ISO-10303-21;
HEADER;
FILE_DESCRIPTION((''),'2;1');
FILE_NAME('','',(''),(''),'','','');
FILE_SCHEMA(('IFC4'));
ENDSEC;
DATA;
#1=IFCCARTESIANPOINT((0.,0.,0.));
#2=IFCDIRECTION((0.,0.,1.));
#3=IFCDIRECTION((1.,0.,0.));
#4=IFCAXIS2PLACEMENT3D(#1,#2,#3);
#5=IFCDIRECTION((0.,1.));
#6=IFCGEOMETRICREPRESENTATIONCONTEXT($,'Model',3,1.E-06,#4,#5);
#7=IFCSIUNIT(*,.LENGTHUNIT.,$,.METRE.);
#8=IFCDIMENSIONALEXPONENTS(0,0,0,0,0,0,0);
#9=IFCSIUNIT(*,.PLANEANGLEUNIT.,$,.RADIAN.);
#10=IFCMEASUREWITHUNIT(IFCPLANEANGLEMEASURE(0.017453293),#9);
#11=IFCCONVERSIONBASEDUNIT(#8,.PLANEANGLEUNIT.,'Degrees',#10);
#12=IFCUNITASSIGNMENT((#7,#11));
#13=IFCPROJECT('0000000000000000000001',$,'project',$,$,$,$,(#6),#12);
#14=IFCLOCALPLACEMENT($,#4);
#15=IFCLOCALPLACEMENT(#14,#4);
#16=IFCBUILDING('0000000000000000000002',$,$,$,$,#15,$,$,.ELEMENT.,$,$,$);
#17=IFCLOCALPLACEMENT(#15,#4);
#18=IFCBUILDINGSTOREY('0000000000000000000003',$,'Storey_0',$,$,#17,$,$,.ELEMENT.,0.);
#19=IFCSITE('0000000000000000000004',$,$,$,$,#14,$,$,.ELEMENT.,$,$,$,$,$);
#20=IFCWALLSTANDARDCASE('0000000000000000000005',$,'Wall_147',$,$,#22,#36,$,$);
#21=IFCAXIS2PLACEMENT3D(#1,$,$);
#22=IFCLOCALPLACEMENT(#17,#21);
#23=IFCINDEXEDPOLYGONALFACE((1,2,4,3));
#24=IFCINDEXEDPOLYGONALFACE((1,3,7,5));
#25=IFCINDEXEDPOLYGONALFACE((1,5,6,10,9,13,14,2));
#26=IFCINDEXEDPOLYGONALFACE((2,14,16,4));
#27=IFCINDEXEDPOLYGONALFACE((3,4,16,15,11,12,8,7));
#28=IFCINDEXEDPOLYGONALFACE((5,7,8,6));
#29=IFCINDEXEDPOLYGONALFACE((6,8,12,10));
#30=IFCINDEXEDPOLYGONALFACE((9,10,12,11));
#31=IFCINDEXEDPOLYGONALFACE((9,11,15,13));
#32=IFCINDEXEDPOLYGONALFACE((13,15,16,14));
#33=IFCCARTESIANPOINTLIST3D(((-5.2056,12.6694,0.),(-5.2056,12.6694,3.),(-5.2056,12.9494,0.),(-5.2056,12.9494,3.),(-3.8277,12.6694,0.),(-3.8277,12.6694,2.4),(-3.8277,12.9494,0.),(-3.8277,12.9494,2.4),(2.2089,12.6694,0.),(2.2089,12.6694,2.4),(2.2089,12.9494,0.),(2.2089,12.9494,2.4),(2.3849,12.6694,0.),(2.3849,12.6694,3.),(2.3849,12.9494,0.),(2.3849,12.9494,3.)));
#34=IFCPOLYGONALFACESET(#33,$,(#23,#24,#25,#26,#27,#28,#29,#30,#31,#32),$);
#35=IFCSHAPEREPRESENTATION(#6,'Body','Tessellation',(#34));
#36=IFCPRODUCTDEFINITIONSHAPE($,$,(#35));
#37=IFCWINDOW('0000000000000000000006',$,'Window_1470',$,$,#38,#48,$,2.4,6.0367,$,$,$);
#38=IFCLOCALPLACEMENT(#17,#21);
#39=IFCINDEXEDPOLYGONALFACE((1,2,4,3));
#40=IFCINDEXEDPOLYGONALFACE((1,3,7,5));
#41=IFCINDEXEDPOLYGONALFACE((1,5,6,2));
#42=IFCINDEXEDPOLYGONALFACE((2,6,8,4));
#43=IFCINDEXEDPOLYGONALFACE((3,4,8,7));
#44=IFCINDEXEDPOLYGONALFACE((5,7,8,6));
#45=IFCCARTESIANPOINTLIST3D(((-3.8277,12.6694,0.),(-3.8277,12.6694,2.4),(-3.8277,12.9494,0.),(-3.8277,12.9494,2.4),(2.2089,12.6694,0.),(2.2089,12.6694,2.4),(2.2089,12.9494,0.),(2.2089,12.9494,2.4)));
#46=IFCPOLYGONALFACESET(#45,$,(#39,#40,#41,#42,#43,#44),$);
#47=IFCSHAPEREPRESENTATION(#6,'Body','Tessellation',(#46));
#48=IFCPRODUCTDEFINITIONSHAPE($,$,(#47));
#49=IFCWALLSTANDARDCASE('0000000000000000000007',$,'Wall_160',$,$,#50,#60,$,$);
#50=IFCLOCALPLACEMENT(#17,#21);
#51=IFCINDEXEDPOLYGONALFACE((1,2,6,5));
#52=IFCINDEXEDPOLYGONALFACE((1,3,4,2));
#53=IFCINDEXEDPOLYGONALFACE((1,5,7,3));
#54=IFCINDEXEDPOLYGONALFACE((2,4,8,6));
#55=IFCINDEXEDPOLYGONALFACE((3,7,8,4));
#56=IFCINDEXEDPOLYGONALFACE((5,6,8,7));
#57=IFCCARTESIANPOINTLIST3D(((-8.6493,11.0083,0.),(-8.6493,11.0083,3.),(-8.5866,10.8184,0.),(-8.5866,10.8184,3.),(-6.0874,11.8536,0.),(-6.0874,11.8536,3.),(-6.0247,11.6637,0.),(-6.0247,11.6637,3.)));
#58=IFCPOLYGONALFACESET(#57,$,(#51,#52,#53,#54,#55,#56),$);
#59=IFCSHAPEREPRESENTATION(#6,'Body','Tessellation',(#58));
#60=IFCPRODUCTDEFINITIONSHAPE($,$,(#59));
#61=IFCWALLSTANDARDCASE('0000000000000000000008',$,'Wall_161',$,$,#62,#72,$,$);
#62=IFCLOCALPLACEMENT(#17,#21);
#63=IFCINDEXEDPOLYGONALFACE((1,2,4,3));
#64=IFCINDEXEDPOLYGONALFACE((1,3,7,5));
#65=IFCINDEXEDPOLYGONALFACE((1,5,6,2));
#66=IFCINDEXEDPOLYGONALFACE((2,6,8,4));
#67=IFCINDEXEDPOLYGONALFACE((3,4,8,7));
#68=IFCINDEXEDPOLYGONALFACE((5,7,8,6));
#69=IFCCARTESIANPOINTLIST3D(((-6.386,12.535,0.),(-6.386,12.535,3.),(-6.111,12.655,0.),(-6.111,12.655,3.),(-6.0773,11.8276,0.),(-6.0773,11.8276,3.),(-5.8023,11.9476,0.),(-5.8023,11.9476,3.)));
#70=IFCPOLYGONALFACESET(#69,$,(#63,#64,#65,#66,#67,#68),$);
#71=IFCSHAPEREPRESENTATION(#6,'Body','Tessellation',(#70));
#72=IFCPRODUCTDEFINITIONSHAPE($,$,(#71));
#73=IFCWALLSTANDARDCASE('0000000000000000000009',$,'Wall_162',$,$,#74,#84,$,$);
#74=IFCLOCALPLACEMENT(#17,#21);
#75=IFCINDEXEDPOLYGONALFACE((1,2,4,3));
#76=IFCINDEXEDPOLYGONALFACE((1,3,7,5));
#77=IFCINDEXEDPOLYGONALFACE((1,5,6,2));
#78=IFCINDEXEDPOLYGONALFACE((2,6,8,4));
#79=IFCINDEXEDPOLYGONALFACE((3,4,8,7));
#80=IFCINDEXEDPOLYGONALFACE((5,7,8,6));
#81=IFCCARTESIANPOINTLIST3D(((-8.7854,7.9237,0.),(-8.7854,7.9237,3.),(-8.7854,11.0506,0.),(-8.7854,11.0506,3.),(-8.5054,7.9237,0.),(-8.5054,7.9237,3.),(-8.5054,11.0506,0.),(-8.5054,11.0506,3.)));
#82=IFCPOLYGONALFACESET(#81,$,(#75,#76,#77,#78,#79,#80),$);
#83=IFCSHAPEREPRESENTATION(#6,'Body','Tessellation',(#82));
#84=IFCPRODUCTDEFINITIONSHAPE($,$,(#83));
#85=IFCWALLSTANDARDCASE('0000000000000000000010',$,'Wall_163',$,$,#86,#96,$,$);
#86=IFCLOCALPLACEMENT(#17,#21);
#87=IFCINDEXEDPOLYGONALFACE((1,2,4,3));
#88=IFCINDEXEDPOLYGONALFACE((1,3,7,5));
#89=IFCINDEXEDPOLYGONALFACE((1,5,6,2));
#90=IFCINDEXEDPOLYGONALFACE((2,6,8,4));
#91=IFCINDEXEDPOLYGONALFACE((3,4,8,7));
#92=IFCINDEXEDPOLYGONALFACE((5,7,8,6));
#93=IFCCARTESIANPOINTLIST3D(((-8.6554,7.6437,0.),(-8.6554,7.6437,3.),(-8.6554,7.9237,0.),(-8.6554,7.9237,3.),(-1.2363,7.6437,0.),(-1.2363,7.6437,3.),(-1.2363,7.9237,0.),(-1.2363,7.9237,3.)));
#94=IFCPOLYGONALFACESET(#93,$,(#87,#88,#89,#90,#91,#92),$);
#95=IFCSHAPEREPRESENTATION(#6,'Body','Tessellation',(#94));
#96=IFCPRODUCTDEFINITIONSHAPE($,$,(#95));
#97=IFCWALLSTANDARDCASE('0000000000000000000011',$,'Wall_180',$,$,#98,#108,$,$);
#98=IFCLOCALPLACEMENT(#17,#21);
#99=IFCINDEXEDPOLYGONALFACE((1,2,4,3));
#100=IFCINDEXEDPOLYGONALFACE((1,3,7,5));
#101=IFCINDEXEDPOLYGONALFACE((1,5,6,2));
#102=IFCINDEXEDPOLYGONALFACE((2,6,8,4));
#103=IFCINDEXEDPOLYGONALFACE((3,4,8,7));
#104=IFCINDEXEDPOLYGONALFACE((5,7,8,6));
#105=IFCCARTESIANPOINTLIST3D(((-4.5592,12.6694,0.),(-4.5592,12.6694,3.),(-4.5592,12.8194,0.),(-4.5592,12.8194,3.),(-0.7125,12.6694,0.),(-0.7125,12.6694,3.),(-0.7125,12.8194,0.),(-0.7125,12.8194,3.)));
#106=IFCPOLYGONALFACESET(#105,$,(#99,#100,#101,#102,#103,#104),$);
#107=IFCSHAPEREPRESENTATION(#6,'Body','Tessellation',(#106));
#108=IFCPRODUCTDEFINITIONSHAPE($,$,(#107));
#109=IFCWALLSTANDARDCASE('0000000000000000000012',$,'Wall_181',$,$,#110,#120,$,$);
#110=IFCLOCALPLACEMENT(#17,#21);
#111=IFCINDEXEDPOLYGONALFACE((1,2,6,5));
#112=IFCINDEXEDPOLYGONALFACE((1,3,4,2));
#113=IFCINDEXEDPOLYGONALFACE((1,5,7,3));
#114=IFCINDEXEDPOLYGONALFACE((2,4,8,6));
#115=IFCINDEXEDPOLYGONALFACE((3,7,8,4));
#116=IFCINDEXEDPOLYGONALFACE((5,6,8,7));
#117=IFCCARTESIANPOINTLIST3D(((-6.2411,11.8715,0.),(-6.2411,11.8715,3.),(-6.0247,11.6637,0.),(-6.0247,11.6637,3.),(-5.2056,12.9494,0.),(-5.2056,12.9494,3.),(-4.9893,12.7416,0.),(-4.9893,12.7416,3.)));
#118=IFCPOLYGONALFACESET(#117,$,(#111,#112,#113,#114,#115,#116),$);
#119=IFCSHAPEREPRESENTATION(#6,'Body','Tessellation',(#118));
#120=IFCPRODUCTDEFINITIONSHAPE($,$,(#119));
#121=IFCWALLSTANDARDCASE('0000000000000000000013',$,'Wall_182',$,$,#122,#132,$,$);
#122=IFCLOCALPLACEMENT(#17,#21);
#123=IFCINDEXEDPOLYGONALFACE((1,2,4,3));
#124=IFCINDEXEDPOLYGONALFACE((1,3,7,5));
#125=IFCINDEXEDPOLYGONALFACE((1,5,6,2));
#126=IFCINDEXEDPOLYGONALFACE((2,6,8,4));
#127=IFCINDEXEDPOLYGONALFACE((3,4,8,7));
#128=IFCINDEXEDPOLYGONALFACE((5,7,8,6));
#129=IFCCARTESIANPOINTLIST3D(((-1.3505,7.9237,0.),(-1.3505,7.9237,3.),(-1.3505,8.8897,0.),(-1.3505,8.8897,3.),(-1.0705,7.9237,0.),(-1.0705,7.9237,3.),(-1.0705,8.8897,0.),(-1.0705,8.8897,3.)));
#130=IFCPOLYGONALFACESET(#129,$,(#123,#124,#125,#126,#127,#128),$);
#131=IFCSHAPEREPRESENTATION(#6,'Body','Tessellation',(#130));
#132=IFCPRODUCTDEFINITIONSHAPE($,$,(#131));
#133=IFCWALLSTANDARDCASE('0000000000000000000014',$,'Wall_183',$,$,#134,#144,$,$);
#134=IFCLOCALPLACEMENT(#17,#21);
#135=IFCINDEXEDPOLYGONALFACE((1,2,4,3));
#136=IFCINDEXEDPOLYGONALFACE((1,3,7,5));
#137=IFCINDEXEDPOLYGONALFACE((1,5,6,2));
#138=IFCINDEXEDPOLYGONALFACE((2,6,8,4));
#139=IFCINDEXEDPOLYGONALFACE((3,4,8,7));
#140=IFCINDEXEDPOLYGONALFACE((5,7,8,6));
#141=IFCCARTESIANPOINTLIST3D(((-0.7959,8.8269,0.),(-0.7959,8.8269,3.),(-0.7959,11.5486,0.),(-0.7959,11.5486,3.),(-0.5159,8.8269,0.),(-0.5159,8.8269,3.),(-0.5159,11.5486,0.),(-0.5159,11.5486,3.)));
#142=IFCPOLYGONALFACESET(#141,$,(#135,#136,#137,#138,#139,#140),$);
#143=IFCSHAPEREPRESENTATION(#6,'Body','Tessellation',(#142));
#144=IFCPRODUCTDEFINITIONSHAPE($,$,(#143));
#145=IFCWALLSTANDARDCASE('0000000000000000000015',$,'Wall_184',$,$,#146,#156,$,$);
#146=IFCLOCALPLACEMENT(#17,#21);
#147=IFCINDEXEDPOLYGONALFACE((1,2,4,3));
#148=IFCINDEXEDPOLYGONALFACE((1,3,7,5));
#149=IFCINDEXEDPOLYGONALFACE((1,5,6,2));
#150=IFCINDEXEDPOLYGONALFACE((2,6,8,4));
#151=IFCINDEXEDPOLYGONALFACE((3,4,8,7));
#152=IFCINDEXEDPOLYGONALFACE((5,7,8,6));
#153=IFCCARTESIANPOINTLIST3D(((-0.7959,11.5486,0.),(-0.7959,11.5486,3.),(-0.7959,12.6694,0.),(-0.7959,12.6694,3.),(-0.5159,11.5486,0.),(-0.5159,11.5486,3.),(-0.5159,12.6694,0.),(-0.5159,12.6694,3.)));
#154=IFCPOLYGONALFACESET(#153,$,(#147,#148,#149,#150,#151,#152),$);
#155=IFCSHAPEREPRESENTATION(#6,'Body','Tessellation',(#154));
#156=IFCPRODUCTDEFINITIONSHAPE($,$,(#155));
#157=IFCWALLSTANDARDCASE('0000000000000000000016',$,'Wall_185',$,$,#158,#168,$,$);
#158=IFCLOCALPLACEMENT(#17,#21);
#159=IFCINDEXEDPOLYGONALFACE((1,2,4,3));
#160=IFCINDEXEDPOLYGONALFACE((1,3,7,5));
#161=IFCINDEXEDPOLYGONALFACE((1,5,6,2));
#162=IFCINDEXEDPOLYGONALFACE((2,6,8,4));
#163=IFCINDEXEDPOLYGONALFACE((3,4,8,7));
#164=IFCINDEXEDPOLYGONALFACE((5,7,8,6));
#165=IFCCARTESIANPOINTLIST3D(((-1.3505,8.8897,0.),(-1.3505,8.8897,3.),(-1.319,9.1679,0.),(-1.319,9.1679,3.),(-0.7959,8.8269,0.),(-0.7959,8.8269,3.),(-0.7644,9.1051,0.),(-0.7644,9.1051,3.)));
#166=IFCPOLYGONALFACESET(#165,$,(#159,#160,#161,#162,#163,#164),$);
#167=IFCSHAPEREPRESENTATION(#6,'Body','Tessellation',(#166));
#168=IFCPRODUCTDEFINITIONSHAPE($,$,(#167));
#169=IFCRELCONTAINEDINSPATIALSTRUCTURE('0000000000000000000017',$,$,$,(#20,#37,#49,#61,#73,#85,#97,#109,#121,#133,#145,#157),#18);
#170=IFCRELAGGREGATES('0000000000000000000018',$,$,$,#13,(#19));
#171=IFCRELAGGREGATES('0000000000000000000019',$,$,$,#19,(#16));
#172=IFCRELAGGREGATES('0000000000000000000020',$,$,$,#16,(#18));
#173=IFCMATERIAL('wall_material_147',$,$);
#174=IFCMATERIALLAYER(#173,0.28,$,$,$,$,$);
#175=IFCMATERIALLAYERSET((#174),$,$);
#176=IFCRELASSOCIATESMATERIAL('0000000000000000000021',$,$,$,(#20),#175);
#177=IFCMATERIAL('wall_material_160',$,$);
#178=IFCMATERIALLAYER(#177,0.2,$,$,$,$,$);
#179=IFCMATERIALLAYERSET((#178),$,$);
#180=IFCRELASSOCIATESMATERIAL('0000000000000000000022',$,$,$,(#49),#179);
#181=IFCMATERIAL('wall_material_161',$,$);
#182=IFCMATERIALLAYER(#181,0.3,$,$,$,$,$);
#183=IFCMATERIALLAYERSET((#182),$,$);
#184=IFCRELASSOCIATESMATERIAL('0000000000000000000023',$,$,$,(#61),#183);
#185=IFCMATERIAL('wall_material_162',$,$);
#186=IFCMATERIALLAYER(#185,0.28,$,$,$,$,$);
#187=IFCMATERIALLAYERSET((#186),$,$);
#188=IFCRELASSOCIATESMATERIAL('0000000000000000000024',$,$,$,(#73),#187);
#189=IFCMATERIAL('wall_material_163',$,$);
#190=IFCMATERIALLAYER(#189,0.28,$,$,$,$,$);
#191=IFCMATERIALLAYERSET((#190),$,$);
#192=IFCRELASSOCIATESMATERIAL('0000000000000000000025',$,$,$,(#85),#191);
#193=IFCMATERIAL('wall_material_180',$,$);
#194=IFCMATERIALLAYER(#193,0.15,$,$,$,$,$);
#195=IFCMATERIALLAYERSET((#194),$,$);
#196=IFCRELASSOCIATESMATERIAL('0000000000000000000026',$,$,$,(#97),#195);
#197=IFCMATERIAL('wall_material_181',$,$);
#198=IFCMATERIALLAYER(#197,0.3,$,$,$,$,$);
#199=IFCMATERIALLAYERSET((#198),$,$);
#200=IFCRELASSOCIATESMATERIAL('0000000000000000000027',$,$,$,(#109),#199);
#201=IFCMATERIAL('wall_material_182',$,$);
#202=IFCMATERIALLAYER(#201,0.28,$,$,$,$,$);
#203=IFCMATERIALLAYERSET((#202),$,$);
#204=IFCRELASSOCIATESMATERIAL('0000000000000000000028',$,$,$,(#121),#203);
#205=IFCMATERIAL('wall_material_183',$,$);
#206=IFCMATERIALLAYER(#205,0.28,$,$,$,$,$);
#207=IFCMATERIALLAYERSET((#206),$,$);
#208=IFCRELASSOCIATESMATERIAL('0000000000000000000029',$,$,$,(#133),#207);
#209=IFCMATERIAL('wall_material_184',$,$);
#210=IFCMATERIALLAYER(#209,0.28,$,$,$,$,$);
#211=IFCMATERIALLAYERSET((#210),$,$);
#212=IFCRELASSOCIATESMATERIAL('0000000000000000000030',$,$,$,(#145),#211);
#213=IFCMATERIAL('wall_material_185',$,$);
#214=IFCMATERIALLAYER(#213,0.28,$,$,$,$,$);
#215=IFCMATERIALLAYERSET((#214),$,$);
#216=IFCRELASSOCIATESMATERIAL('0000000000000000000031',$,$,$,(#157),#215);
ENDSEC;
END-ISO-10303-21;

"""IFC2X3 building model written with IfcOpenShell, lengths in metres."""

from ifc_helpers import new_model, entity, si_unit, converted_unit, direction, frame, frame_2d, origin_with_axes, place, context, project, spatial, polyline, rectangle, outline, extrude, material, layer, layer_set, layer_usage, element, fill, save


model = new_model("IFC2X3")

# Units and contexts
model_context = context("Model", 3, precision=1e-06, world=origin_with_axes(), true_north=direction((0.0, 1.0)))
ifc_project = project(units=[si_unit("LENGTHUNIT", "METRE"), converted_unit("PLANEANGLEUNIT", "Degrees", entity("IfcPlaneAngleMeasure", 0.017453293), si_unit("PLANEANGLEUNIT", "RADIAN"), dimensions=[0, 0, 0, 0, 0, 0, 0])], contexts=[model_context])

# Site, building, storey
site_placement = place(None, origin_with_axes())
site = spatial("IfcSite", under=ifc_project, at=site_placement, CompositionType="ELEMENT")
building_placement = place(site_placement, origin_with_axes())
building = spatial("IfcBuilding", under=site, at=building_placement, CompositionType="ELEMENT")
storey_placement = place(building_placement, origin_with_axes())
storey = spatial("IfcBuildingStorey", under=building, at=storey_placement, Name="Storey_0", CompositionType="ELEMENT", Elevation=0.0)

# Wall, opening, window
ifc_material_1 = material(Name="wall_material_147")
ifc_layer_1 = layer(ifc_material_1, 0.28)
ifc_layer_set_1 = layer_set([ifc_layer_1])
ifc_layer_usage_1 = layer_usage(ifc_layer_set_1, "AXIS2", "NEGATIVE", 0.0)
wall_1_placement = place(storey_placement, frame((-5.2056, 12.9494, 0.0), z_axis=(0.0, 0.0, 1.0), x_axis=(1.0, 0.0, 0.0)))
wall_1 = element("IfcWallStandardCase", 1, at=wall_1_placement, inside=storey, material=ifc_layer_usage_1, Name="Wall_147", context=model_context, shape_type="SweptSolid", body=[
    extrude(outline(polyline([(0.0, 0.0), (7.5905, 0.0), (7.5905, -0.28), (0.0, -0.28), (0.0, 0.0)])), origin_with_axes(), (0.0, 0.0, 1.0), 3.0),
])
opening_placement = place(wall_1_placement, frame((1.3779, 0.0, 0.0), z_axis=(0.0, 0.0, 1.0), x_axis=(1.0, 0.0, 0.0)))
opening = element("IfcOpeningElement", 2, at=opening_placement, cuts=wall_1, context=model_context, shape_type="SweptSolid", body=[
    extrude(rectangle(XDim=6.0367, YDim=2.4, at=frame_2d((1.2, -3.0183), x_axis=(0.0, 1.0))), frame((0.0, 0.01, 0.0), z_axis=(0.0, -1.0, 0.0), x_axis=(0.0, 0.0, 1.0)), (0.0, 0.0, 1.0), 0.3),
])
window_placement = place(storey_placement, origin_with_axes())
window = element("IfcWindow", 3, at=window_placement, inside=storey, Name="Window_1470", OverallHeight=2.4, OverallWidth=6.0367, context=model_context, shape_type="SweptSolid", body=[
    extrude(outline(polyline([(-3.8277, 12.9494), (2.2089, 12.9494), (2.2089, 12.6694), (-3.8277, 12.6694), (-3.8277, 12.9494)])), origin_with_axes(), (0.0, 0.0, 1.0), 2.4),
])
fill(opening, window)

# Walls
ifc_material_2 = material(Name="wall_material_160")
ifc_layer_2 = layer(ifc_material_2, 0.2)
ifc_layer_set_2 = layer_set([ifc_layer_2])
ifc_layer_usage_2 = layer_usage(ifc_layer_set_2, "AXIS2", "NEGATIVE", 0.0)
wall_2_placement = place(storey_placement, frame((-8.6493, 11.0083, 0.0), z_axis=(0.0, 0.0, 1.0), x_axis=(0.949644, 0.31333, 0.0)))
element("IfcWallStandardCase", 4, at=wall_2_placement, inside=storey, material=ifc_layer_usage_2, Name="Wall_160", context=model_context, shape_type="SweptSolid", body=[
    extrude(outline(polyline([(0.0, 0.0), (2.6977, 0.0), (2.6977, -0.2), (0.0, -0.2), (0.0, 0.0)])), origin_with_axes(), (0.0, 0.0, 1.0), 3.0),
])
ifc_material_3 = material(Name="wall_material_161")
ifc_layer_3 = layer(ifc_material_3, 0.3)
ifc_layer_set_3 = layer_set([ifc_layer_3])
ifc_layer_usage_3 = layer_usage(ifc_layer_set_3, "AXIS2", "NEGATIVE", 0.0)
wall_3_placement = place(storey_placement, frame((-6.111, 12.655, 0.0), z_axis=(0.0, 0.0, 1.0), x_axis=(0.400029, -0.916502, 0.0)))
element("IfcWallStandardCase", 5, at=wall_3_placement, inside=storey, material=ifc_layer_usage_3, Name="Wall_161", context=model_context, shape_type="SweptSolid", body=[
    extrude(outline(polyline([(0.0, 0.0), (0.7718, 0.0), (0.7718, -0.3), (0.0, -0.3), (0.0, 0.0)])), origin_with_axes(), (0.0, 0.0, 1.0), 3.0),
])
ifc_material_4 = material(Name="wall_material_162")
ifc_layer_4 = layer(ifc_material_4, 0.28)
ifc_layer_set_4 = layer_set([ifc_layer_4])
ifc_layer_usage_4 = layer_usage(ifc_layer_set_4, "AXIS2", "NEGATIVE", 0.0)
wall_4_placement = place(storey_placement, frame((-8.5054, 11.0506, 0.0), z_axis=(0.0, 0.0, 1.0), x_axis=(0.0, -1.0, 0.0)))
element("IfcWallStandardCase", 6, at=wall_4_placement, inside=storey, material=ifc_layer_usage_4, Name="Wall_162", context=model_context, shape_type="SweptSolid", body=[
    extrude(outline(polyline([(0.0, 0.0), (3.127, 0.0), (3.127, -0.28), (0.0, -0.28), (0.0, 0.0)])), origin_with_axes(), (0.0, 0.0, 1.0), 3.0),
])
ifc_material_5 = material(Name="wall_material_163")
ifc_layer_5 = layer(ifc_material_5, 0.28)
ifc_layer_set_5 = layer_set([ifc_layer_5])
ifc_layer_usage_5 = layer_usage(ifc_layer_set_5, "AXIS2", "NEGATIVE", 0.0)
wall_5_placement = place(storey_placement, frame((-8.6554, 7.9237, 0.0), z_axis=(0.0, 0.0, 1.0), x_axis=(1.0, 0.0, 0.0)))
element("IfcWallStandardCase", 7, at=wall_5_placement, inside=storey, material=ifc_layer_usage_5, Name="Wall_163", context=model_context, shape_type="SweptSolid", body=[
    extrude(outline(polyline([(0.0, 0.0), (7.4191, 0.0), (7.4191, -0.28), (0.0, -0.28), (0.0, 0.0)])), origin_with_axes(), (0.0, 0.0, 1.0), 3.0),
])
ifc_material_6 = material(Name="wall_material_180")
ifc_layer_6 = layer(ifc_material_6, 0.15)
ifc_layer_set_6 = layer_set([ifc_layer_6])
ifc_layer_usage_6 = layer_usage(ifc_layer_set_6, "AXIS2", "NEGATIVE", 0.0)
wall_6_placement = place(storey_placement, frame((-0.7125, 12.6694, 0.0), z_axis=(0.0, 0.0, 1.0), x_axis=(-1.0, 0.0, 0.0)))
element("IfcWallStandardCase", 8, at=wall_6_placement, inside=storey, material=ifc_layer_usage_6, Name="Wall_180", context=model_context, shape_type="SweptSolid", body=[
    extrude(outline(polyline([(0.0, 0.0), (3.8468, 0.0), (3.8468, -0.15), (0.0, -0.15), (0.0, 0.0)])), origin_with_axes(), (0.0, 0.0, 1.0), 3.0),
])
ifc_material_7 = material(Name="wall_material_181")
ifc_layer_7 = layer(ifc_material_7, 0.3)
ifc_layer_set_7 = layer_set([ifc_layer_7])
ifc_layer_usage_7 = layer_usage(ifc_layer_set_7, "AXIS2", "NEGATIVE", 0.0)
wall_7_placement = place(storey_placement, frame((-4.9893, 12.7416, 0.0), z_axis=(0.0, 0.0, 1.0), x_axis=(-0.692773, -0.721156, 0.0)))
element("IfcWallStandardCase", 9, at=wall_7_placement, inside=storey, material=ifc_layer_usage_7, Name="Wall_181", context=model_context, shape_type="SweptSolid", body=[
    extrude(outline(polyline([(0.0, 0.0), (1.4947, 0.0), (1.4947, -0.3), (0.0, -0.3), (0.0, 0.0)])), origin_with_axes(), (0.0, 0.0, 1.0), 3.0),
])
ifc_material_8 = material(Name="wall_material_182")
ifc_layer_8 = layer(ifc_material_8, 0.28)
ifc_layer_set_8 = layer_set([ifc_layer_8])
ifc_layer_usage_8 = layer_usage(ifc_layer_set_8, "AXIS2", "NEGATIVE", 0.0)
wall_8_placement = place(storey_placement, frame((-1.3505, 7.9237, 0.0), z_axis=(0.0, 0.0, 1.0), x_axis=(0.0, 1.0, 0.0)))
element("IfcWallStandardCase", 10, at=wall_8_placement, inside=storey, material=ifc_layer_usage_8, Name="Wall_182", context=model_context, shape_type="SweptSolid", body=[
    extrude(outline(polyline([(0.0, 0.0), (0.966, 0.0), (0.966, -0.28), (0.0, -0.28), (0.0, 0.0)])), origin_with_axes(), (0.0, 0.0, 1.0), 3.0),
])
ifc_material_9 = material(Name="wall_material_183")
ifc_layer_9 = layer(ifc_material_9, 0.28)
ifc_layer_set_9 = layer_set([ifc_layer_9])
ifc_layer_usage_9 = layer_usage(ifc_layer_set_9, "AXIS2", "NEGATIVE", 0.0)
wall_9_placement = place(storey_placement, frame((-0.7959, 8.8269, 0.0), z_axis=(0.0, 0.0, 1.0), x_axis=(0.0, 1.0, 0.0)))
element("IfcWallStandardCase", 11, at=wall_9_placement, inside=storey, material=ifc_layer_usage_9, Name="Wall_183", context=model_context, shape_type="SweptSolid", body=[
    extrude(outline(polyline([(0.0, 0.0), (2.7217, 0.0), (2.7217, -0.28), (0.0, -0.28), (0.0, 0.0)])), origin_with_axes(), (0.0, 0.0, 1.0), 3.0),
])
ifc_material_10 = material(Name="wall_material_184")
ifc_layer_10 = layer(ifc_material_10, 0.28)
ifc_layer_set_10 = layer_set([ifc_layer_10])
ifc_layer_usage_10 = layer_usage(ifc_layer_set_10, "AXIS2", "NEGATIVE", 0.0)
wall_10_placement = place(storey_placement, frame((-0.7959, 11.5486, 0.0), z_axis=(0.0, 0.0, 1.0), x_axis=(0.0, 1.0, 0.0)))
element("IfcWallStandardCase", 12, at=wall_10_placement, inside=storey, material=ifc_layer_usage_10, Name="Wall_184", context=model_context, shape_type="SweptSolid", body=[
    extrude(outline(polyline([(0.0, 0.0), (1.1208, 0.0), (1.1208, -0.28), (0.0, -0.28), (0.0, 0.0)])), origin_with_axes(), (0.0, 0.0, 1.0), 3.0),
])
ifc_material_11 = material(Name="wall_material_185")
ifc_layer_11 = layer(ifc_material_11, 0.28)
ifc_layer_set_11 = layer_set([ifc_layer_11])
ifc_layer_usage_11 = layer_usage(ifc_layer_set_11, "AXIS2", "NEGATIVE", 0.0)
wall_11_placement = place(storey_placement, frame((-0.7959, 8.8269, 0.0), z_axis=(0.0, 0.0, 1.0), x_axis=(-0.993651, 0.11251, 0.0)))
element("IfcWallStandardCase", 13, at=wall_11_placement, inside=storey, material=ifc_layer_usage_11, Name="Wall_185", context=model_context, shape_type="SweptSolid", body=[
    extrude(outline(polyline([(0.0, 0.0), (0.5581, 0.0), (0.5581, -0.28), (0.0, -0.28), (0.0, 0.0)])), origin_with_axes(), (0.0, 0.0, 1.0), 3.0),
])

save(model, "model.ifc")
